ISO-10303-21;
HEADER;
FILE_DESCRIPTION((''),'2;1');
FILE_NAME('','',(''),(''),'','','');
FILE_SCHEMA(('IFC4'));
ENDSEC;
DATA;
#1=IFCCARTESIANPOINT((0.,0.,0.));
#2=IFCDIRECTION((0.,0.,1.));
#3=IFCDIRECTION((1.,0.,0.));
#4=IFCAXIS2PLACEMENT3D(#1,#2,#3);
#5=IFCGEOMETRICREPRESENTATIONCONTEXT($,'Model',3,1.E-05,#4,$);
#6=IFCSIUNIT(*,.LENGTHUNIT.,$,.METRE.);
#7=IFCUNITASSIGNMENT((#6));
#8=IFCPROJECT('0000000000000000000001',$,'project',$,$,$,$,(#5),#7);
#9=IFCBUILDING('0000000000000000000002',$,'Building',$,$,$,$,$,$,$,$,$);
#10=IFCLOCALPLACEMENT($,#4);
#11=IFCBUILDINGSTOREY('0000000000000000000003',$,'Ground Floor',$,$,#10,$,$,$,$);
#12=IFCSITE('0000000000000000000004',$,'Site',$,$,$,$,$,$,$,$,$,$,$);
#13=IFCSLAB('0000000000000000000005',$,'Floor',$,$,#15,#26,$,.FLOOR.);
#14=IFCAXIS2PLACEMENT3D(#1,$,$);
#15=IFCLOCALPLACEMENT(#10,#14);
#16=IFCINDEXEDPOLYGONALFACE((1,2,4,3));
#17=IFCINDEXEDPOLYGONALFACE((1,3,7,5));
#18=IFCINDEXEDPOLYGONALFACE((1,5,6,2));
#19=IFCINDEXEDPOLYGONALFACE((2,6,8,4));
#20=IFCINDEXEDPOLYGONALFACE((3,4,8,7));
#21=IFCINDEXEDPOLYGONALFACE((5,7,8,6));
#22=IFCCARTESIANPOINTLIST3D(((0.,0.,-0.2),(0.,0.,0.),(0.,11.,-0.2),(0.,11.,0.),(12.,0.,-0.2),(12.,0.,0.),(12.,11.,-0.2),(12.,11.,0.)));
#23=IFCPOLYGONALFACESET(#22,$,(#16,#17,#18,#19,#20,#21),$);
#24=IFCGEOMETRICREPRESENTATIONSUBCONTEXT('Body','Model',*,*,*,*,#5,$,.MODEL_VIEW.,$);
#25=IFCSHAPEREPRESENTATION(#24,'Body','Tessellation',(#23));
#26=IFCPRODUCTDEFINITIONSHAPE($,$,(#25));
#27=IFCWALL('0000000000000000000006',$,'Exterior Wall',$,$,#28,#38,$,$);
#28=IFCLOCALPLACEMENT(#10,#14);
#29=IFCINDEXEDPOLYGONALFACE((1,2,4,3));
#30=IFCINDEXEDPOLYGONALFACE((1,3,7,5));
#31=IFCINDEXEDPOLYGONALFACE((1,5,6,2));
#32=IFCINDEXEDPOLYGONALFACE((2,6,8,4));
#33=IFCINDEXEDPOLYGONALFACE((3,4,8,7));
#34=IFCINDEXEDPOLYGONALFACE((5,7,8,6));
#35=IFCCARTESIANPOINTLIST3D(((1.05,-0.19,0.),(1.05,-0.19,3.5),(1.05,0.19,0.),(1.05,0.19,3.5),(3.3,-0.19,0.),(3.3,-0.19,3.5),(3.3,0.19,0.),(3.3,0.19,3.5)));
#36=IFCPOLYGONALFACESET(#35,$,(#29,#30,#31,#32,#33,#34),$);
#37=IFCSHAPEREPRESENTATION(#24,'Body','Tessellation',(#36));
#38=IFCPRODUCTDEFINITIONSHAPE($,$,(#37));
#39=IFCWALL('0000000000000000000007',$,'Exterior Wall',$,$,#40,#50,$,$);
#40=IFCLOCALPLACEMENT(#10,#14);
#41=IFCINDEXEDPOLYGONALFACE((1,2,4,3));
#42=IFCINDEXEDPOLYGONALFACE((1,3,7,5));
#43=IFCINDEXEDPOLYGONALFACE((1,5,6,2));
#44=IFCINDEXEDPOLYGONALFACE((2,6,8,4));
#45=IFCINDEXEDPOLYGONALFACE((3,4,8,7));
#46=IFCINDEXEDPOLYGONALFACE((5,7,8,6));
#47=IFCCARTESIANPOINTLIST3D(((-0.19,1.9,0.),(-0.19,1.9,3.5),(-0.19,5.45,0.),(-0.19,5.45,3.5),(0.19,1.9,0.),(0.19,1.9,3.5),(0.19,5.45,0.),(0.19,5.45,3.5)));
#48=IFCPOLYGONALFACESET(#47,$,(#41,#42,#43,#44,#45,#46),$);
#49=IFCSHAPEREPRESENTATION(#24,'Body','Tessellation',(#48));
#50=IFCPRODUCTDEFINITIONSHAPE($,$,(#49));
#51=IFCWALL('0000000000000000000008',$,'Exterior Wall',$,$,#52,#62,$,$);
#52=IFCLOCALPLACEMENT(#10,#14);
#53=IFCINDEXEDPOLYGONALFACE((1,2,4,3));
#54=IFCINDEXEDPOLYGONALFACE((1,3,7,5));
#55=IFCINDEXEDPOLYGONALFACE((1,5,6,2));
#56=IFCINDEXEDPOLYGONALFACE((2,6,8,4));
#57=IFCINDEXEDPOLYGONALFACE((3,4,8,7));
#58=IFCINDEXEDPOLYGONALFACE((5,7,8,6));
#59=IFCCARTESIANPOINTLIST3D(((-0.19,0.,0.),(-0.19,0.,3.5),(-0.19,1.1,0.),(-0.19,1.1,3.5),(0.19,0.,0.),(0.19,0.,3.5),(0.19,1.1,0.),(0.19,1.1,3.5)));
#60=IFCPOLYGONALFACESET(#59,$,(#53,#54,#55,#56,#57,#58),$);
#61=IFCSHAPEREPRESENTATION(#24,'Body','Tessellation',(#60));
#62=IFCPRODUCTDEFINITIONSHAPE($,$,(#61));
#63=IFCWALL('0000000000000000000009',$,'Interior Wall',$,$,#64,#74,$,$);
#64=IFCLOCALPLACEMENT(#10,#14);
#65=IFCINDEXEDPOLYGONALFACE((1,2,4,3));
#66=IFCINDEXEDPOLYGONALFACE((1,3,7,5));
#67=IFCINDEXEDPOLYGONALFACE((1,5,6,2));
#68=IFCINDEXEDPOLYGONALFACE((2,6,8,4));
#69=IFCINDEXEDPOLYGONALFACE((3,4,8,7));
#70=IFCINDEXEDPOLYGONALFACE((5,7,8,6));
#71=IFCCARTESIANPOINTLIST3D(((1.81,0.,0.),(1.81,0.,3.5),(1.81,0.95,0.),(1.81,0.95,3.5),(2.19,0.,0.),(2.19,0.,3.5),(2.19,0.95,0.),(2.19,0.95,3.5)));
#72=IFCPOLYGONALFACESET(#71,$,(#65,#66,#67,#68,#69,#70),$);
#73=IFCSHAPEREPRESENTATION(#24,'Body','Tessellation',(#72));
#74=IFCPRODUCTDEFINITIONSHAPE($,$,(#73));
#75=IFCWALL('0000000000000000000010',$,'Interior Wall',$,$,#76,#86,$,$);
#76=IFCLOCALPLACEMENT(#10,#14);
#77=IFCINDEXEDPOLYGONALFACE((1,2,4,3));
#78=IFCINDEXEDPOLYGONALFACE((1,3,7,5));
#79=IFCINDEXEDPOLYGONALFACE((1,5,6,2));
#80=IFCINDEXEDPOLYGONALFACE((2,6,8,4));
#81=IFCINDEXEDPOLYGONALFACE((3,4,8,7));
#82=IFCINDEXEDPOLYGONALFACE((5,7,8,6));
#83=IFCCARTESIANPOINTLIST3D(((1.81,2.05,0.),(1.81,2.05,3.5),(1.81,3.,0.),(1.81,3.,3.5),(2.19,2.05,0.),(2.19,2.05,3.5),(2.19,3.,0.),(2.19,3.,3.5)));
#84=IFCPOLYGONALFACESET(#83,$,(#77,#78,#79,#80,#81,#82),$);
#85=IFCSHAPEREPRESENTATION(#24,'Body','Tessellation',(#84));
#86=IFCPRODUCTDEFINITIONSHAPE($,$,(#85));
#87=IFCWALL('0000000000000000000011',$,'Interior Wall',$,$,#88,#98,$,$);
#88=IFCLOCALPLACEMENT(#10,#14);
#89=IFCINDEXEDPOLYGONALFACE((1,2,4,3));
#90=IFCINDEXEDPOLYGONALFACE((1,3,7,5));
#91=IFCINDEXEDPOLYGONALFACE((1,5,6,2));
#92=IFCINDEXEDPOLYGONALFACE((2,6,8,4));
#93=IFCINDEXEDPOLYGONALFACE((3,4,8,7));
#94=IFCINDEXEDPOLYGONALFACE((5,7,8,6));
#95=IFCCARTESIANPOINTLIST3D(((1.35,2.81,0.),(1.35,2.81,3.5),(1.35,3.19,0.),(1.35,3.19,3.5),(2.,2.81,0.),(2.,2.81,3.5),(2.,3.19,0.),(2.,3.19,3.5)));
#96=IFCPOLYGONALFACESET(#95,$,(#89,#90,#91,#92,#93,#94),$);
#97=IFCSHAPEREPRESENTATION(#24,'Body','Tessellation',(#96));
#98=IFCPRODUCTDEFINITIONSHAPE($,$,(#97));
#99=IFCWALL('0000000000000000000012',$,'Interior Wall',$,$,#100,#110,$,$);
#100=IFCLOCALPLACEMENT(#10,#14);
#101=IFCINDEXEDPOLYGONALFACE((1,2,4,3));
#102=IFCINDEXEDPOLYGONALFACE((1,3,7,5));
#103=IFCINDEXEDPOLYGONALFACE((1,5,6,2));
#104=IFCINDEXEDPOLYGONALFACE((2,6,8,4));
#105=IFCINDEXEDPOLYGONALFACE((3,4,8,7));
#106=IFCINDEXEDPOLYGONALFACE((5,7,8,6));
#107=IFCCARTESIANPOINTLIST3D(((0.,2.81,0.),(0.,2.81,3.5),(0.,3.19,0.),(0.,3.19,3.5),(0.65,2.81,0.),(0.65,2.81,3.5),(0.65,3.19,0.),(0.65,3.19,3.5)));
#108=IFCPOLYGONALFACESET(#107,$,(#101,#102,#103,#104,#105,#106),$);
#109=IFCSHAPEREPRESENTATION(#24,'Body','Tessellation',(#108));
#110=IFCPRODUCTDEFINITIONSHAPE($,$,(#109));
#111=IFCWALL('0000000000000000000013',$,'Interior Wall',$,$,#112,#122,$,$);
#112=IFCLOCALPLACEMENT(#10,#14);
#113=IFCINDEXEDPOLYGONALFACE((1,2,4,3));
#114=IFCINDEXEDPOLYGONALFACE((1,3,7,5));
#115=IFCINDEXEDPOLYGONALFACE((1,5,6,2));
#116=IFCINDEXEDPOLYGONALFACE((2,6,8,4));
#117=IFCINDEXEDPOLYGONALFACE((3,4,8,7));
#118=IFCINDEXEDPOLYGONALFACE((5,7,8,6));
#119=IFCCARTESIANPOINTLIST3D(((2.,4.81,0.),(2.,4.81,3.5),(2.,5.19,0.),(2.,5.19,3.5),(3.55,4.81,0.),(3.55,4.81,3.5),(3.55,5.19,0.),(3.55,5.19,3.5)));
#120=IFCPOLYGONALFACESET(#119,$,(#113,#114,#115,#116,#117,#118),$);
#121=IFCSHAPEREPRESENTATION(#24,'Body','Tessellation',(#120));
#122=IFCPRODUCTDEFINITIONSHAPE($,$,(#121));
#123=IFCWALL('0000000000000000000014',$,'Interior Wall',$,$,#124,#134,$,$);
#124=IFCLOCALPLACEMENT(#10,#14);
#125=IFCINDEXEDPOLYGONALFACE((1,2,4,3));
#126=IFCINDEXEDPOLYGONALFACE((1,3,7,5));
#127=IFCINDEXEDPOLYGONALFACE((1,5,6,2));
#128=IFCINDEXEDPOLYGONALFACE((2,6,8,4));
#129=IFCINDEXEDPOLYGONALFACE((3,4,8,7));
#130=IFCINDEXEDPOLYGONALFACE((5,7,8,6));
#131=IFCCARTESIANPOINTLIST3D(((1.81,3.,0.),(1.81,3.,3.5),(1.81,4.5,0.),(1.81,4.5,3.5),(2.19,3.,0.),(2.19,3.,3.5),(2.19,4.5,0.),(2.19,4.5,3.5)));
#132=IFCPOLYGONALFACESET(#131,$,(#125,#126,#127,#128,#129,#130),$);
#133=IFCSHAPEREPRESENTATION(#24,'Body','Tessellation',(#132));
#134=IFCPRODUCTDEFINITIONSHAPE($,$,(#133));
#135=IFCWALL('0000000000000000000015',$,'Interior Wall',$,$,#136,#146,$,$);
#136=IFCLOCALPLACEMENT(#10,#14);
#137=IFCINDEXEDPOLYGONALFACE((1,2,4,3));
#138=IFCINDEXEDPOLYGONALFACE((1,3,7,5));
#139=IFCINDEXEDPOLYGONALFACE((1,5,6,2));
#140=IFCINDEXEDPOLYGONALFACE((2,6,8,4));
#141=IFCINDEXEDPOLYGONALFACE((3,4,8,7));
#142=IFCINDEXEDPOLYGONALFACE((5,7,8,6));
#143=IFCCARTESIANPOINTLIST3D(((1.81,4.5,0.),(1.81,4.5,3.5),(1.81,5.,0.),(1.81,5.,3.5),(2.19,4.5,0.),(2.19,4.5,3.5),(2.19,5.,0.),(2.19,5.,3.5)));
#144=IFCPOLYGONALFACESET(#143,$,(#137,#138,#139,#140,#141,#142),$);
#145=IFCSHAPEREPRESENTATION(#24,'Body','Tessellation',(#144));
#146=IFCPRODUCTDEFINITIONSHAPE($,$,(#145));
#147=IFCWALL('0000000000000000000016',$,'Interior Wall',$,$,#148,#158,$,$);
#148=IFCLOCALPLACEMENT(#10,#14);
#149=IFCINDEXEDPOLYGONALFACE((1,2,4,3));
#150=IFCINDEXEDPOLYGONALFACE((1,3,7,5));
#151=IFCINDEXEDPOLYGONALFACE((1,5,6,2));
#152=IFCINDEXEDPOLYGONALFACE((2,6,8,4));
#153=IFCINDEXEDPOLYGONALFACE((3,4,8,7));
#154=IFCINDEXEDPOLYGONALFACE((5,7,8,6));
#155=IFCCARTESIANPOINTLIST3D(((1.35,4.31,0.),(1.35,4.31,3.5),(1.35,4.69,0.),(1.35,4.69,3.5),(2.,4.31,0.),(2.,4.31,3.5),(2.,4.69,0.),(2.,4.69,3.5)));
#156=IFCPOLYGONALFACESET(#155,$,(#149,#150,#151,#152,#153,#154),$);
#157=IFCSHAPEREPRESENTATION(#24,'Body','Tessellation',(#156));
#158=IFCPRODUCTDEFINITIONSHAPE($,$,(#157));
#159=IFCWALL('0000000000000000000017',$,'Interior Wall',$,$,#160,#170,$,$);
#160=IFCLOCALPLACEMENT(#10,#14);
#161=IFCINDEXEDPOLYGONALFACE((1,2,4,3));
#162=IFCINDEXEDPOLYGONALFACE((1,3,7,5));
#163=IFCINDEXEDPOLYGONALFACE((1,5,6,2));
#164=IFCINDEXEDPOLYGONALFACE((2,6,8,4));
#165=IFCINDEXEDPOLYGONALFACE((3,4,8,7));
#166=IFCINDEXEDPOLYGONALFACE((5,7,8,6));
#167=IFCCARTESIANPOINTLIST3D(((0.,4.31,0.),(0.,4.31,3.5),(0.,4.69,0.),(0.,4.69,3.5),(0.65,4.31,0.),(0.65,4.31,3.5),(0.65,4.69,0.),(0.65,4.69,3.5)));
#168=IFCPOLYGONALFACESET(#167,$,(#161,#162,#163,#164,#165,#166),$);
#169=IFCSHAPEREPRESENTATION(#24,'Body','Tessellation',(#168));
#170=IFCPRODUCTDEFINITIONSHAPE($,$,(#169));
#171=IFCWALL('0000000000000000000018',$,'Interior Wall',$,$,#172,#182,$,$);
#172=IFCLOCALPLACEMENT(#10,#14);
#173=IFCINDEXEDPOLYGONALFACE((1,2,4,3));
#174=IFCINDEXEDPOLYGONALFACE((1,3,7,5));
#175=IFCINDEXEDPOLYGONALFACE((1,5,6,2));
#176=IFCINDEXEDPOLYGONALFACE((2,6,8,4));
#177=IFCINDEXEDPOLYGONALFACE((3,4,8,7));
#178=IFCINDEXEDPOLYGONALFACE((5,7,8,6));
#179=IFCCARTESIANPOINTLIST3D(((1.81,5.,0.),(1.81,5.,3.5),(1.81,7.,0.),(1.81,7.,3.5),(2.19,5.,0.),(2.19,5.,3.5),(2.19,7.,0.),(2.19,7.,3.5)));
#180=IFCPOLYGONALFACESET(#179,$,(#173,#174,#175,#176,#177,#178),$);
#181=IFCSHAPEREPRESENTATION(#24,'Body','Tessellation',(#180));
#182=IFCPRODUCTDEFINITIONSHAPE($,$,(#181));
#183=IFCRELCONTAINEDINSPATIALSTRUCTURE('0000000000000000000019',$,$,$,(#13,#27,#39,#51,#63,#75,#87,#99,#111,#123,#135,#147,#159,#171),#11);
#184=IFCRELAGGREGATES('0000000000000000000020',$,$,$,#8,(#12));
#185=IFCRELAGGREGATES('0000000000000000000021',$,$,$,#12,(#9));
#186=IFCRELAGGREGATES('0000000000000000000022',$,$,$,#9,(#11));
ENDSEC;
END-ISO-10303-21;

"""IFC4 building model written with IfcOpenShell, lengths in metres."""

from ifc_helpers import new_model, si_unit, frame, origin_with_axes, place, context, subcontext, project, spatial, indexed_curve, outline, extrude, element, save


model = new_model("IFC4")

# Units and contexts
model_context = context("Model", 3, precision=1e-05, world=origin_with_axes())
body_context = subcontext(model_context, "Body", "Model", "MODEL_VIEW")
ifc_project = project(units=[si_unit("LENGTHUNIT", "METRE")], contexts=[model_context])

# Site, building, storey
site = spatial("IfcSite", under=ifc_project, Name="Site")
building = spatial("IfcBuilding", under=site, Name="Building")
storey_placement = place(None, origin_with_axes())
storey = spatial("IfcBuildingStorey", under=building, at=storey_placement, Name="Ground Floor")

# Slab
slab_placement = place(storey_placement, frame((0.0, 0.0, -0.2), z_axis=(0.0, 0.0, 1.0), x_axis=(1.0, 0.0, 0.0)))
element("IfcSlab", 1, at=slab_placement, inside=storey, Name="Floor", PredefinedType="FLOOR", context=body_context, shape_type="SweptSolid", body=[
    extrude(outline(indexed_curve([(0.0, 0.0), (12.0, 0.0), (12.0, 11.0), (0.0, 11.0)])), None, (0.0, 0.0, 1.0), 0.2),
])

# Walls
wall_1_placement = place(storey_placement, frame((1.05, 0.0, 0.0), z_axis=(0.0, 0.0, 1.0), x_axis=(1.0, 0.0, 0.0)))
element("IfcWall", 2, at=wall_1_placement, inside=storey, Name="Exterior Wall", context=body_context, shape_type="SweptSolid", body=[
    extrude(outline(indexed_curve([(0.0, 0.0), (0.0, 0.38), (2.25, 0.38), (2.25, 0.0), (0.0, 0.0)], self_intersect=False)), frame((0.0, -0.19, 0.0), z_axis=(0.0, 0.0, 1.0), x_axis=(1.0, 0.0, 0.0)), (0.0, 0.0, 1.0), 3.5),
])
wall_2_placement = place(storey_placement, frame((0.0, 5.45, 0.0), z_axis=(0.0, 0.0, 1.0), x_axis=(0.0, -1.0, 0.0)))
element("IfcWall", 3, at=wall_2_placement, inside=storey, Name="Exterior Wall", context=body_context, shape_type="SweptSolid", body=[
    extrude(outline(indexed_curve([(0.0, 0.0), (0.0, 0.38), (3.55, 0.38), (3.55, 0.0), (0.0, 0.0)], self_intersect=False)), frame((0.0, -0.19, 0.0), z_axis=(0.0, 0.0, 1.0), x_axis=(1.0, 0.0, 0.0)), (0.0, 0.0, 1.0), 3.5),
])
wall_3_placement = place(storey_placement, frame((0.0, 1.1, 0.0), z_axis=(0.0, 0.0, 1.0), x_axis=(0.0, -1.0, 0.0)))
element("IfcWall", 4, at=wall_3_placement, inside=storey, Name="Exterior Wall", context=body_context, shape_type="SweptSolid", body=[
    extrude(outline(indexed_curve([(0.0, 0.0), (0.0, 0.38), (1.1, 0.38), (1.1, 0.0), (0.0, 0.0)], self_intersect=False)), frame((0.0, -0.19, 0.0), z_axis=(0.0, 0.0, 1.0), x_axis=(1.0, 0.0, 0.0)), (0.0, 0.0, 1.0), 3.5),
])
wall_4_placement = place(storey_placement, frame((2.0, 0.0, 0.0), z_axis=(0.0, 0.0, 1.0), x_axis=(0.0, 1.0, 0.0)))
element("IfcWall", 5, at=wall_4_placement, inside=storey, Name="Interior Wall", context=body_context, shape_type="SweptSolid", body=[
    extrude(outline(indexed_curve([(0.0, 0.0), (0.0, 0.38), (0.95, 0.38), (0.95, 0.0), (0.0, 0.0)], self_intersect=False)), frame((0.0, -0.19, 0.0), z_axis=(0.0, 0.0, 1.0), x_axis=(1.0, 0.0, 0.0)), (0.0, 0.0, 1.0), 3.5),
])
wall_5_placement = place(storey_placement, frame((2.0, 2.05, 0.0), z_axis=(0.0, 0.0, 1.0), x_axis=(0.0, 1.0, 0.0)))
element("IfcWall", 6, at=wall_5_placement, inside=storey, Name="Interior Wall", context=body_context, shape_type="SweptSolid", body=[
    extrude(outline(indexed_curve([(0.0, 0.0), (0.0, 0.38), (0.95, 0.38), (0.95, 0.0), (0.0, 0.0)], self_intersect=False)), frame((0.0, -0.19, 0.0), z_axis=(0.0, 0.0, 1.0), x_axis=(1.0, 0.0, 0.0)), (0.0, 0.0, 1.0), 3.5),
])
for number, where, z_axis, x_axis, name in (
    (7, (2.0, 3.0, 0.0), (0.0, 0.0, 1.0), (-1.0, 0.0, 0.0), "Interior Wall"),
    (8, (0.65, 3.0, 0.0), (0.0, 0.0, 1.0), (-1.0, 0.0, 0.0), "Interior Wall"),
):
    element("IfcWall", number, at=place(storey_placement, frame(where, z_axis=z_axis, x_axis=x_axis)), inside=storey, Name=name, context=body_context, shape_type="SweptSolid", body=[
        extrude(outline(indexed_curve([(0.0, 0.0), (0.0, 0.38), (0.65, 0.38), (0.65, 0.0), (0.0, 0.0)], self_intersect=False)), frame((0.0, -0.19, 0.0), z_axis=(0.0, 0.0, 1.0), x_axis=(1.0, 0.0, 0.0)), (0.0, 0.0, 1.0), 3.5),
    ])
wall_6_placement = place(storey_placement, frame((3.55, 5.0, 0.0), z_axis=(0.0, 0.0, 1.0), x_axis=(-1.0, 0.0, 0.0)))
element("IfcWall", 9, at=wall_6_placement, inside=storey, Name="Interior Wall", context=body_context, shape_type="SweptSolid", body=[
    extrude(outline(indexed_curve([(0.0, 0.0), (0.0, 0.38), (1.55, 0.38), (1.55, 0.0), (0.0, 0.0)], self_intersect=False)), frame((0.0, -0.19, 0.0), z_axis=(0.0, 0.0, 1.0), x_axis=(1.0, 0.0, 0.0)), (0.0, 0.0, 1.0), 3.5),
])
wall_7_placement = place(storey_placement, frame((2.0, 4.5, 0.0), z_axis=(0.0, 0.0, 1.0), x_axis=(0.0, -1.0, 0.0)))
element("IfcWall", 10, at=wall_7_placement, inside=storey, Name="Interior Wall", context=body_context, shape_type="SweptSolid", body=[
    extrude(outline(indexed_curve([(0.0, 0.0), (0.0, 0.38), (1.5, 0.38), (1.5, 0.0), (0.0, 0.0)], self_intersect=False)), frame((0.0, -0.19, 0.0), z_axis=(0.0, 0.0, 1.0), x_axis=(1.0, 0.0, 0.0)), (0.0, 0.0, 1.0), 3.5),
])
wall_8_placement = place(storey_placement, frame((2.0, 5.0, 0.0), z_axis=(0.0, 0.0, 1.0), x_axis=(0.0, -1.0, 0.0)))
element("IfcWall", 11, at=wall_8_placement, inside=storey, Name="Interior Wall", context=body_context, shape_type="SweptSolid", body=[
    extrude(outline(indexed_curve([(0.0, 0.0), (0.0, 0.38), (0.5, 0.38), (0.5, 0.0), (0.0, 0.0)], self_intersect=False)), frame((0.0, -0.19, 0.0), z_axis=(0.0, 0.0, 1.0), x_axis=(1.0, 0.0, 0.0)), (0.0, 0.0, 1.0), 3.5),
])
for number, where, z_axis, x_axis, name in (
    (12, (2.0, 4.5, 0.0), (0.0, 0.0, 1.0), (-1.0, 0.0, 0.0), "Interior Wall"),
    (13, (0.65, 4.5, 0.0), (0.0, 0.0, 1.0), (-1.0, 0.0, 0.0), "Interior Wall"),
):
    element("IfcWall", number, at=place(storey_placement, frame(where, z_axis=z_axis, x_axis=x_axis)), inside=storey, Name=name, context=body_context, shape_type="SweptSolid", body=[
        extrude(outline(indexed_curve([(0.0, 0.0), (0.0, 0.38), (0.65, 0.38), (0.65, 0.0), (0.0, 0.0)], self_intersect=False)), frame((0.0, -0.19, 0.0), z_axis=(0.0, 0.0, 1.0), x_axis=(1.0, 0.0, 0.0)), (0.0, 0.0, 1.0), 3.5),
    ])
wall_9_placement = place(storey_placement, frame((2.0, 5.0, 0.0), z_axis=(0.0, 0.0, 1.0), x_axis=(0.0, 1.0, 0.0)))
element("IfcWall", 14, at=wall_9_placement, inside=storey, Name="Interior Wall", context=body_context, shape_type="SweptSolid", body=[
    extrude(outline(indexed_curve([(0.0, 0.0), (0.0, 0.38), (2.0, 0.38), (2.0, 0.0), (0.0, 0.0)], self_intersect=False)), frame((0.0, -0.19, 0.0), z_axis=(0.0, 0.0, 1.0), x_axis=(1.0, 0.0, 0.0)), (0.0, 0.0, 1.0), 3.5),
])

save(model, "model.ifc")
